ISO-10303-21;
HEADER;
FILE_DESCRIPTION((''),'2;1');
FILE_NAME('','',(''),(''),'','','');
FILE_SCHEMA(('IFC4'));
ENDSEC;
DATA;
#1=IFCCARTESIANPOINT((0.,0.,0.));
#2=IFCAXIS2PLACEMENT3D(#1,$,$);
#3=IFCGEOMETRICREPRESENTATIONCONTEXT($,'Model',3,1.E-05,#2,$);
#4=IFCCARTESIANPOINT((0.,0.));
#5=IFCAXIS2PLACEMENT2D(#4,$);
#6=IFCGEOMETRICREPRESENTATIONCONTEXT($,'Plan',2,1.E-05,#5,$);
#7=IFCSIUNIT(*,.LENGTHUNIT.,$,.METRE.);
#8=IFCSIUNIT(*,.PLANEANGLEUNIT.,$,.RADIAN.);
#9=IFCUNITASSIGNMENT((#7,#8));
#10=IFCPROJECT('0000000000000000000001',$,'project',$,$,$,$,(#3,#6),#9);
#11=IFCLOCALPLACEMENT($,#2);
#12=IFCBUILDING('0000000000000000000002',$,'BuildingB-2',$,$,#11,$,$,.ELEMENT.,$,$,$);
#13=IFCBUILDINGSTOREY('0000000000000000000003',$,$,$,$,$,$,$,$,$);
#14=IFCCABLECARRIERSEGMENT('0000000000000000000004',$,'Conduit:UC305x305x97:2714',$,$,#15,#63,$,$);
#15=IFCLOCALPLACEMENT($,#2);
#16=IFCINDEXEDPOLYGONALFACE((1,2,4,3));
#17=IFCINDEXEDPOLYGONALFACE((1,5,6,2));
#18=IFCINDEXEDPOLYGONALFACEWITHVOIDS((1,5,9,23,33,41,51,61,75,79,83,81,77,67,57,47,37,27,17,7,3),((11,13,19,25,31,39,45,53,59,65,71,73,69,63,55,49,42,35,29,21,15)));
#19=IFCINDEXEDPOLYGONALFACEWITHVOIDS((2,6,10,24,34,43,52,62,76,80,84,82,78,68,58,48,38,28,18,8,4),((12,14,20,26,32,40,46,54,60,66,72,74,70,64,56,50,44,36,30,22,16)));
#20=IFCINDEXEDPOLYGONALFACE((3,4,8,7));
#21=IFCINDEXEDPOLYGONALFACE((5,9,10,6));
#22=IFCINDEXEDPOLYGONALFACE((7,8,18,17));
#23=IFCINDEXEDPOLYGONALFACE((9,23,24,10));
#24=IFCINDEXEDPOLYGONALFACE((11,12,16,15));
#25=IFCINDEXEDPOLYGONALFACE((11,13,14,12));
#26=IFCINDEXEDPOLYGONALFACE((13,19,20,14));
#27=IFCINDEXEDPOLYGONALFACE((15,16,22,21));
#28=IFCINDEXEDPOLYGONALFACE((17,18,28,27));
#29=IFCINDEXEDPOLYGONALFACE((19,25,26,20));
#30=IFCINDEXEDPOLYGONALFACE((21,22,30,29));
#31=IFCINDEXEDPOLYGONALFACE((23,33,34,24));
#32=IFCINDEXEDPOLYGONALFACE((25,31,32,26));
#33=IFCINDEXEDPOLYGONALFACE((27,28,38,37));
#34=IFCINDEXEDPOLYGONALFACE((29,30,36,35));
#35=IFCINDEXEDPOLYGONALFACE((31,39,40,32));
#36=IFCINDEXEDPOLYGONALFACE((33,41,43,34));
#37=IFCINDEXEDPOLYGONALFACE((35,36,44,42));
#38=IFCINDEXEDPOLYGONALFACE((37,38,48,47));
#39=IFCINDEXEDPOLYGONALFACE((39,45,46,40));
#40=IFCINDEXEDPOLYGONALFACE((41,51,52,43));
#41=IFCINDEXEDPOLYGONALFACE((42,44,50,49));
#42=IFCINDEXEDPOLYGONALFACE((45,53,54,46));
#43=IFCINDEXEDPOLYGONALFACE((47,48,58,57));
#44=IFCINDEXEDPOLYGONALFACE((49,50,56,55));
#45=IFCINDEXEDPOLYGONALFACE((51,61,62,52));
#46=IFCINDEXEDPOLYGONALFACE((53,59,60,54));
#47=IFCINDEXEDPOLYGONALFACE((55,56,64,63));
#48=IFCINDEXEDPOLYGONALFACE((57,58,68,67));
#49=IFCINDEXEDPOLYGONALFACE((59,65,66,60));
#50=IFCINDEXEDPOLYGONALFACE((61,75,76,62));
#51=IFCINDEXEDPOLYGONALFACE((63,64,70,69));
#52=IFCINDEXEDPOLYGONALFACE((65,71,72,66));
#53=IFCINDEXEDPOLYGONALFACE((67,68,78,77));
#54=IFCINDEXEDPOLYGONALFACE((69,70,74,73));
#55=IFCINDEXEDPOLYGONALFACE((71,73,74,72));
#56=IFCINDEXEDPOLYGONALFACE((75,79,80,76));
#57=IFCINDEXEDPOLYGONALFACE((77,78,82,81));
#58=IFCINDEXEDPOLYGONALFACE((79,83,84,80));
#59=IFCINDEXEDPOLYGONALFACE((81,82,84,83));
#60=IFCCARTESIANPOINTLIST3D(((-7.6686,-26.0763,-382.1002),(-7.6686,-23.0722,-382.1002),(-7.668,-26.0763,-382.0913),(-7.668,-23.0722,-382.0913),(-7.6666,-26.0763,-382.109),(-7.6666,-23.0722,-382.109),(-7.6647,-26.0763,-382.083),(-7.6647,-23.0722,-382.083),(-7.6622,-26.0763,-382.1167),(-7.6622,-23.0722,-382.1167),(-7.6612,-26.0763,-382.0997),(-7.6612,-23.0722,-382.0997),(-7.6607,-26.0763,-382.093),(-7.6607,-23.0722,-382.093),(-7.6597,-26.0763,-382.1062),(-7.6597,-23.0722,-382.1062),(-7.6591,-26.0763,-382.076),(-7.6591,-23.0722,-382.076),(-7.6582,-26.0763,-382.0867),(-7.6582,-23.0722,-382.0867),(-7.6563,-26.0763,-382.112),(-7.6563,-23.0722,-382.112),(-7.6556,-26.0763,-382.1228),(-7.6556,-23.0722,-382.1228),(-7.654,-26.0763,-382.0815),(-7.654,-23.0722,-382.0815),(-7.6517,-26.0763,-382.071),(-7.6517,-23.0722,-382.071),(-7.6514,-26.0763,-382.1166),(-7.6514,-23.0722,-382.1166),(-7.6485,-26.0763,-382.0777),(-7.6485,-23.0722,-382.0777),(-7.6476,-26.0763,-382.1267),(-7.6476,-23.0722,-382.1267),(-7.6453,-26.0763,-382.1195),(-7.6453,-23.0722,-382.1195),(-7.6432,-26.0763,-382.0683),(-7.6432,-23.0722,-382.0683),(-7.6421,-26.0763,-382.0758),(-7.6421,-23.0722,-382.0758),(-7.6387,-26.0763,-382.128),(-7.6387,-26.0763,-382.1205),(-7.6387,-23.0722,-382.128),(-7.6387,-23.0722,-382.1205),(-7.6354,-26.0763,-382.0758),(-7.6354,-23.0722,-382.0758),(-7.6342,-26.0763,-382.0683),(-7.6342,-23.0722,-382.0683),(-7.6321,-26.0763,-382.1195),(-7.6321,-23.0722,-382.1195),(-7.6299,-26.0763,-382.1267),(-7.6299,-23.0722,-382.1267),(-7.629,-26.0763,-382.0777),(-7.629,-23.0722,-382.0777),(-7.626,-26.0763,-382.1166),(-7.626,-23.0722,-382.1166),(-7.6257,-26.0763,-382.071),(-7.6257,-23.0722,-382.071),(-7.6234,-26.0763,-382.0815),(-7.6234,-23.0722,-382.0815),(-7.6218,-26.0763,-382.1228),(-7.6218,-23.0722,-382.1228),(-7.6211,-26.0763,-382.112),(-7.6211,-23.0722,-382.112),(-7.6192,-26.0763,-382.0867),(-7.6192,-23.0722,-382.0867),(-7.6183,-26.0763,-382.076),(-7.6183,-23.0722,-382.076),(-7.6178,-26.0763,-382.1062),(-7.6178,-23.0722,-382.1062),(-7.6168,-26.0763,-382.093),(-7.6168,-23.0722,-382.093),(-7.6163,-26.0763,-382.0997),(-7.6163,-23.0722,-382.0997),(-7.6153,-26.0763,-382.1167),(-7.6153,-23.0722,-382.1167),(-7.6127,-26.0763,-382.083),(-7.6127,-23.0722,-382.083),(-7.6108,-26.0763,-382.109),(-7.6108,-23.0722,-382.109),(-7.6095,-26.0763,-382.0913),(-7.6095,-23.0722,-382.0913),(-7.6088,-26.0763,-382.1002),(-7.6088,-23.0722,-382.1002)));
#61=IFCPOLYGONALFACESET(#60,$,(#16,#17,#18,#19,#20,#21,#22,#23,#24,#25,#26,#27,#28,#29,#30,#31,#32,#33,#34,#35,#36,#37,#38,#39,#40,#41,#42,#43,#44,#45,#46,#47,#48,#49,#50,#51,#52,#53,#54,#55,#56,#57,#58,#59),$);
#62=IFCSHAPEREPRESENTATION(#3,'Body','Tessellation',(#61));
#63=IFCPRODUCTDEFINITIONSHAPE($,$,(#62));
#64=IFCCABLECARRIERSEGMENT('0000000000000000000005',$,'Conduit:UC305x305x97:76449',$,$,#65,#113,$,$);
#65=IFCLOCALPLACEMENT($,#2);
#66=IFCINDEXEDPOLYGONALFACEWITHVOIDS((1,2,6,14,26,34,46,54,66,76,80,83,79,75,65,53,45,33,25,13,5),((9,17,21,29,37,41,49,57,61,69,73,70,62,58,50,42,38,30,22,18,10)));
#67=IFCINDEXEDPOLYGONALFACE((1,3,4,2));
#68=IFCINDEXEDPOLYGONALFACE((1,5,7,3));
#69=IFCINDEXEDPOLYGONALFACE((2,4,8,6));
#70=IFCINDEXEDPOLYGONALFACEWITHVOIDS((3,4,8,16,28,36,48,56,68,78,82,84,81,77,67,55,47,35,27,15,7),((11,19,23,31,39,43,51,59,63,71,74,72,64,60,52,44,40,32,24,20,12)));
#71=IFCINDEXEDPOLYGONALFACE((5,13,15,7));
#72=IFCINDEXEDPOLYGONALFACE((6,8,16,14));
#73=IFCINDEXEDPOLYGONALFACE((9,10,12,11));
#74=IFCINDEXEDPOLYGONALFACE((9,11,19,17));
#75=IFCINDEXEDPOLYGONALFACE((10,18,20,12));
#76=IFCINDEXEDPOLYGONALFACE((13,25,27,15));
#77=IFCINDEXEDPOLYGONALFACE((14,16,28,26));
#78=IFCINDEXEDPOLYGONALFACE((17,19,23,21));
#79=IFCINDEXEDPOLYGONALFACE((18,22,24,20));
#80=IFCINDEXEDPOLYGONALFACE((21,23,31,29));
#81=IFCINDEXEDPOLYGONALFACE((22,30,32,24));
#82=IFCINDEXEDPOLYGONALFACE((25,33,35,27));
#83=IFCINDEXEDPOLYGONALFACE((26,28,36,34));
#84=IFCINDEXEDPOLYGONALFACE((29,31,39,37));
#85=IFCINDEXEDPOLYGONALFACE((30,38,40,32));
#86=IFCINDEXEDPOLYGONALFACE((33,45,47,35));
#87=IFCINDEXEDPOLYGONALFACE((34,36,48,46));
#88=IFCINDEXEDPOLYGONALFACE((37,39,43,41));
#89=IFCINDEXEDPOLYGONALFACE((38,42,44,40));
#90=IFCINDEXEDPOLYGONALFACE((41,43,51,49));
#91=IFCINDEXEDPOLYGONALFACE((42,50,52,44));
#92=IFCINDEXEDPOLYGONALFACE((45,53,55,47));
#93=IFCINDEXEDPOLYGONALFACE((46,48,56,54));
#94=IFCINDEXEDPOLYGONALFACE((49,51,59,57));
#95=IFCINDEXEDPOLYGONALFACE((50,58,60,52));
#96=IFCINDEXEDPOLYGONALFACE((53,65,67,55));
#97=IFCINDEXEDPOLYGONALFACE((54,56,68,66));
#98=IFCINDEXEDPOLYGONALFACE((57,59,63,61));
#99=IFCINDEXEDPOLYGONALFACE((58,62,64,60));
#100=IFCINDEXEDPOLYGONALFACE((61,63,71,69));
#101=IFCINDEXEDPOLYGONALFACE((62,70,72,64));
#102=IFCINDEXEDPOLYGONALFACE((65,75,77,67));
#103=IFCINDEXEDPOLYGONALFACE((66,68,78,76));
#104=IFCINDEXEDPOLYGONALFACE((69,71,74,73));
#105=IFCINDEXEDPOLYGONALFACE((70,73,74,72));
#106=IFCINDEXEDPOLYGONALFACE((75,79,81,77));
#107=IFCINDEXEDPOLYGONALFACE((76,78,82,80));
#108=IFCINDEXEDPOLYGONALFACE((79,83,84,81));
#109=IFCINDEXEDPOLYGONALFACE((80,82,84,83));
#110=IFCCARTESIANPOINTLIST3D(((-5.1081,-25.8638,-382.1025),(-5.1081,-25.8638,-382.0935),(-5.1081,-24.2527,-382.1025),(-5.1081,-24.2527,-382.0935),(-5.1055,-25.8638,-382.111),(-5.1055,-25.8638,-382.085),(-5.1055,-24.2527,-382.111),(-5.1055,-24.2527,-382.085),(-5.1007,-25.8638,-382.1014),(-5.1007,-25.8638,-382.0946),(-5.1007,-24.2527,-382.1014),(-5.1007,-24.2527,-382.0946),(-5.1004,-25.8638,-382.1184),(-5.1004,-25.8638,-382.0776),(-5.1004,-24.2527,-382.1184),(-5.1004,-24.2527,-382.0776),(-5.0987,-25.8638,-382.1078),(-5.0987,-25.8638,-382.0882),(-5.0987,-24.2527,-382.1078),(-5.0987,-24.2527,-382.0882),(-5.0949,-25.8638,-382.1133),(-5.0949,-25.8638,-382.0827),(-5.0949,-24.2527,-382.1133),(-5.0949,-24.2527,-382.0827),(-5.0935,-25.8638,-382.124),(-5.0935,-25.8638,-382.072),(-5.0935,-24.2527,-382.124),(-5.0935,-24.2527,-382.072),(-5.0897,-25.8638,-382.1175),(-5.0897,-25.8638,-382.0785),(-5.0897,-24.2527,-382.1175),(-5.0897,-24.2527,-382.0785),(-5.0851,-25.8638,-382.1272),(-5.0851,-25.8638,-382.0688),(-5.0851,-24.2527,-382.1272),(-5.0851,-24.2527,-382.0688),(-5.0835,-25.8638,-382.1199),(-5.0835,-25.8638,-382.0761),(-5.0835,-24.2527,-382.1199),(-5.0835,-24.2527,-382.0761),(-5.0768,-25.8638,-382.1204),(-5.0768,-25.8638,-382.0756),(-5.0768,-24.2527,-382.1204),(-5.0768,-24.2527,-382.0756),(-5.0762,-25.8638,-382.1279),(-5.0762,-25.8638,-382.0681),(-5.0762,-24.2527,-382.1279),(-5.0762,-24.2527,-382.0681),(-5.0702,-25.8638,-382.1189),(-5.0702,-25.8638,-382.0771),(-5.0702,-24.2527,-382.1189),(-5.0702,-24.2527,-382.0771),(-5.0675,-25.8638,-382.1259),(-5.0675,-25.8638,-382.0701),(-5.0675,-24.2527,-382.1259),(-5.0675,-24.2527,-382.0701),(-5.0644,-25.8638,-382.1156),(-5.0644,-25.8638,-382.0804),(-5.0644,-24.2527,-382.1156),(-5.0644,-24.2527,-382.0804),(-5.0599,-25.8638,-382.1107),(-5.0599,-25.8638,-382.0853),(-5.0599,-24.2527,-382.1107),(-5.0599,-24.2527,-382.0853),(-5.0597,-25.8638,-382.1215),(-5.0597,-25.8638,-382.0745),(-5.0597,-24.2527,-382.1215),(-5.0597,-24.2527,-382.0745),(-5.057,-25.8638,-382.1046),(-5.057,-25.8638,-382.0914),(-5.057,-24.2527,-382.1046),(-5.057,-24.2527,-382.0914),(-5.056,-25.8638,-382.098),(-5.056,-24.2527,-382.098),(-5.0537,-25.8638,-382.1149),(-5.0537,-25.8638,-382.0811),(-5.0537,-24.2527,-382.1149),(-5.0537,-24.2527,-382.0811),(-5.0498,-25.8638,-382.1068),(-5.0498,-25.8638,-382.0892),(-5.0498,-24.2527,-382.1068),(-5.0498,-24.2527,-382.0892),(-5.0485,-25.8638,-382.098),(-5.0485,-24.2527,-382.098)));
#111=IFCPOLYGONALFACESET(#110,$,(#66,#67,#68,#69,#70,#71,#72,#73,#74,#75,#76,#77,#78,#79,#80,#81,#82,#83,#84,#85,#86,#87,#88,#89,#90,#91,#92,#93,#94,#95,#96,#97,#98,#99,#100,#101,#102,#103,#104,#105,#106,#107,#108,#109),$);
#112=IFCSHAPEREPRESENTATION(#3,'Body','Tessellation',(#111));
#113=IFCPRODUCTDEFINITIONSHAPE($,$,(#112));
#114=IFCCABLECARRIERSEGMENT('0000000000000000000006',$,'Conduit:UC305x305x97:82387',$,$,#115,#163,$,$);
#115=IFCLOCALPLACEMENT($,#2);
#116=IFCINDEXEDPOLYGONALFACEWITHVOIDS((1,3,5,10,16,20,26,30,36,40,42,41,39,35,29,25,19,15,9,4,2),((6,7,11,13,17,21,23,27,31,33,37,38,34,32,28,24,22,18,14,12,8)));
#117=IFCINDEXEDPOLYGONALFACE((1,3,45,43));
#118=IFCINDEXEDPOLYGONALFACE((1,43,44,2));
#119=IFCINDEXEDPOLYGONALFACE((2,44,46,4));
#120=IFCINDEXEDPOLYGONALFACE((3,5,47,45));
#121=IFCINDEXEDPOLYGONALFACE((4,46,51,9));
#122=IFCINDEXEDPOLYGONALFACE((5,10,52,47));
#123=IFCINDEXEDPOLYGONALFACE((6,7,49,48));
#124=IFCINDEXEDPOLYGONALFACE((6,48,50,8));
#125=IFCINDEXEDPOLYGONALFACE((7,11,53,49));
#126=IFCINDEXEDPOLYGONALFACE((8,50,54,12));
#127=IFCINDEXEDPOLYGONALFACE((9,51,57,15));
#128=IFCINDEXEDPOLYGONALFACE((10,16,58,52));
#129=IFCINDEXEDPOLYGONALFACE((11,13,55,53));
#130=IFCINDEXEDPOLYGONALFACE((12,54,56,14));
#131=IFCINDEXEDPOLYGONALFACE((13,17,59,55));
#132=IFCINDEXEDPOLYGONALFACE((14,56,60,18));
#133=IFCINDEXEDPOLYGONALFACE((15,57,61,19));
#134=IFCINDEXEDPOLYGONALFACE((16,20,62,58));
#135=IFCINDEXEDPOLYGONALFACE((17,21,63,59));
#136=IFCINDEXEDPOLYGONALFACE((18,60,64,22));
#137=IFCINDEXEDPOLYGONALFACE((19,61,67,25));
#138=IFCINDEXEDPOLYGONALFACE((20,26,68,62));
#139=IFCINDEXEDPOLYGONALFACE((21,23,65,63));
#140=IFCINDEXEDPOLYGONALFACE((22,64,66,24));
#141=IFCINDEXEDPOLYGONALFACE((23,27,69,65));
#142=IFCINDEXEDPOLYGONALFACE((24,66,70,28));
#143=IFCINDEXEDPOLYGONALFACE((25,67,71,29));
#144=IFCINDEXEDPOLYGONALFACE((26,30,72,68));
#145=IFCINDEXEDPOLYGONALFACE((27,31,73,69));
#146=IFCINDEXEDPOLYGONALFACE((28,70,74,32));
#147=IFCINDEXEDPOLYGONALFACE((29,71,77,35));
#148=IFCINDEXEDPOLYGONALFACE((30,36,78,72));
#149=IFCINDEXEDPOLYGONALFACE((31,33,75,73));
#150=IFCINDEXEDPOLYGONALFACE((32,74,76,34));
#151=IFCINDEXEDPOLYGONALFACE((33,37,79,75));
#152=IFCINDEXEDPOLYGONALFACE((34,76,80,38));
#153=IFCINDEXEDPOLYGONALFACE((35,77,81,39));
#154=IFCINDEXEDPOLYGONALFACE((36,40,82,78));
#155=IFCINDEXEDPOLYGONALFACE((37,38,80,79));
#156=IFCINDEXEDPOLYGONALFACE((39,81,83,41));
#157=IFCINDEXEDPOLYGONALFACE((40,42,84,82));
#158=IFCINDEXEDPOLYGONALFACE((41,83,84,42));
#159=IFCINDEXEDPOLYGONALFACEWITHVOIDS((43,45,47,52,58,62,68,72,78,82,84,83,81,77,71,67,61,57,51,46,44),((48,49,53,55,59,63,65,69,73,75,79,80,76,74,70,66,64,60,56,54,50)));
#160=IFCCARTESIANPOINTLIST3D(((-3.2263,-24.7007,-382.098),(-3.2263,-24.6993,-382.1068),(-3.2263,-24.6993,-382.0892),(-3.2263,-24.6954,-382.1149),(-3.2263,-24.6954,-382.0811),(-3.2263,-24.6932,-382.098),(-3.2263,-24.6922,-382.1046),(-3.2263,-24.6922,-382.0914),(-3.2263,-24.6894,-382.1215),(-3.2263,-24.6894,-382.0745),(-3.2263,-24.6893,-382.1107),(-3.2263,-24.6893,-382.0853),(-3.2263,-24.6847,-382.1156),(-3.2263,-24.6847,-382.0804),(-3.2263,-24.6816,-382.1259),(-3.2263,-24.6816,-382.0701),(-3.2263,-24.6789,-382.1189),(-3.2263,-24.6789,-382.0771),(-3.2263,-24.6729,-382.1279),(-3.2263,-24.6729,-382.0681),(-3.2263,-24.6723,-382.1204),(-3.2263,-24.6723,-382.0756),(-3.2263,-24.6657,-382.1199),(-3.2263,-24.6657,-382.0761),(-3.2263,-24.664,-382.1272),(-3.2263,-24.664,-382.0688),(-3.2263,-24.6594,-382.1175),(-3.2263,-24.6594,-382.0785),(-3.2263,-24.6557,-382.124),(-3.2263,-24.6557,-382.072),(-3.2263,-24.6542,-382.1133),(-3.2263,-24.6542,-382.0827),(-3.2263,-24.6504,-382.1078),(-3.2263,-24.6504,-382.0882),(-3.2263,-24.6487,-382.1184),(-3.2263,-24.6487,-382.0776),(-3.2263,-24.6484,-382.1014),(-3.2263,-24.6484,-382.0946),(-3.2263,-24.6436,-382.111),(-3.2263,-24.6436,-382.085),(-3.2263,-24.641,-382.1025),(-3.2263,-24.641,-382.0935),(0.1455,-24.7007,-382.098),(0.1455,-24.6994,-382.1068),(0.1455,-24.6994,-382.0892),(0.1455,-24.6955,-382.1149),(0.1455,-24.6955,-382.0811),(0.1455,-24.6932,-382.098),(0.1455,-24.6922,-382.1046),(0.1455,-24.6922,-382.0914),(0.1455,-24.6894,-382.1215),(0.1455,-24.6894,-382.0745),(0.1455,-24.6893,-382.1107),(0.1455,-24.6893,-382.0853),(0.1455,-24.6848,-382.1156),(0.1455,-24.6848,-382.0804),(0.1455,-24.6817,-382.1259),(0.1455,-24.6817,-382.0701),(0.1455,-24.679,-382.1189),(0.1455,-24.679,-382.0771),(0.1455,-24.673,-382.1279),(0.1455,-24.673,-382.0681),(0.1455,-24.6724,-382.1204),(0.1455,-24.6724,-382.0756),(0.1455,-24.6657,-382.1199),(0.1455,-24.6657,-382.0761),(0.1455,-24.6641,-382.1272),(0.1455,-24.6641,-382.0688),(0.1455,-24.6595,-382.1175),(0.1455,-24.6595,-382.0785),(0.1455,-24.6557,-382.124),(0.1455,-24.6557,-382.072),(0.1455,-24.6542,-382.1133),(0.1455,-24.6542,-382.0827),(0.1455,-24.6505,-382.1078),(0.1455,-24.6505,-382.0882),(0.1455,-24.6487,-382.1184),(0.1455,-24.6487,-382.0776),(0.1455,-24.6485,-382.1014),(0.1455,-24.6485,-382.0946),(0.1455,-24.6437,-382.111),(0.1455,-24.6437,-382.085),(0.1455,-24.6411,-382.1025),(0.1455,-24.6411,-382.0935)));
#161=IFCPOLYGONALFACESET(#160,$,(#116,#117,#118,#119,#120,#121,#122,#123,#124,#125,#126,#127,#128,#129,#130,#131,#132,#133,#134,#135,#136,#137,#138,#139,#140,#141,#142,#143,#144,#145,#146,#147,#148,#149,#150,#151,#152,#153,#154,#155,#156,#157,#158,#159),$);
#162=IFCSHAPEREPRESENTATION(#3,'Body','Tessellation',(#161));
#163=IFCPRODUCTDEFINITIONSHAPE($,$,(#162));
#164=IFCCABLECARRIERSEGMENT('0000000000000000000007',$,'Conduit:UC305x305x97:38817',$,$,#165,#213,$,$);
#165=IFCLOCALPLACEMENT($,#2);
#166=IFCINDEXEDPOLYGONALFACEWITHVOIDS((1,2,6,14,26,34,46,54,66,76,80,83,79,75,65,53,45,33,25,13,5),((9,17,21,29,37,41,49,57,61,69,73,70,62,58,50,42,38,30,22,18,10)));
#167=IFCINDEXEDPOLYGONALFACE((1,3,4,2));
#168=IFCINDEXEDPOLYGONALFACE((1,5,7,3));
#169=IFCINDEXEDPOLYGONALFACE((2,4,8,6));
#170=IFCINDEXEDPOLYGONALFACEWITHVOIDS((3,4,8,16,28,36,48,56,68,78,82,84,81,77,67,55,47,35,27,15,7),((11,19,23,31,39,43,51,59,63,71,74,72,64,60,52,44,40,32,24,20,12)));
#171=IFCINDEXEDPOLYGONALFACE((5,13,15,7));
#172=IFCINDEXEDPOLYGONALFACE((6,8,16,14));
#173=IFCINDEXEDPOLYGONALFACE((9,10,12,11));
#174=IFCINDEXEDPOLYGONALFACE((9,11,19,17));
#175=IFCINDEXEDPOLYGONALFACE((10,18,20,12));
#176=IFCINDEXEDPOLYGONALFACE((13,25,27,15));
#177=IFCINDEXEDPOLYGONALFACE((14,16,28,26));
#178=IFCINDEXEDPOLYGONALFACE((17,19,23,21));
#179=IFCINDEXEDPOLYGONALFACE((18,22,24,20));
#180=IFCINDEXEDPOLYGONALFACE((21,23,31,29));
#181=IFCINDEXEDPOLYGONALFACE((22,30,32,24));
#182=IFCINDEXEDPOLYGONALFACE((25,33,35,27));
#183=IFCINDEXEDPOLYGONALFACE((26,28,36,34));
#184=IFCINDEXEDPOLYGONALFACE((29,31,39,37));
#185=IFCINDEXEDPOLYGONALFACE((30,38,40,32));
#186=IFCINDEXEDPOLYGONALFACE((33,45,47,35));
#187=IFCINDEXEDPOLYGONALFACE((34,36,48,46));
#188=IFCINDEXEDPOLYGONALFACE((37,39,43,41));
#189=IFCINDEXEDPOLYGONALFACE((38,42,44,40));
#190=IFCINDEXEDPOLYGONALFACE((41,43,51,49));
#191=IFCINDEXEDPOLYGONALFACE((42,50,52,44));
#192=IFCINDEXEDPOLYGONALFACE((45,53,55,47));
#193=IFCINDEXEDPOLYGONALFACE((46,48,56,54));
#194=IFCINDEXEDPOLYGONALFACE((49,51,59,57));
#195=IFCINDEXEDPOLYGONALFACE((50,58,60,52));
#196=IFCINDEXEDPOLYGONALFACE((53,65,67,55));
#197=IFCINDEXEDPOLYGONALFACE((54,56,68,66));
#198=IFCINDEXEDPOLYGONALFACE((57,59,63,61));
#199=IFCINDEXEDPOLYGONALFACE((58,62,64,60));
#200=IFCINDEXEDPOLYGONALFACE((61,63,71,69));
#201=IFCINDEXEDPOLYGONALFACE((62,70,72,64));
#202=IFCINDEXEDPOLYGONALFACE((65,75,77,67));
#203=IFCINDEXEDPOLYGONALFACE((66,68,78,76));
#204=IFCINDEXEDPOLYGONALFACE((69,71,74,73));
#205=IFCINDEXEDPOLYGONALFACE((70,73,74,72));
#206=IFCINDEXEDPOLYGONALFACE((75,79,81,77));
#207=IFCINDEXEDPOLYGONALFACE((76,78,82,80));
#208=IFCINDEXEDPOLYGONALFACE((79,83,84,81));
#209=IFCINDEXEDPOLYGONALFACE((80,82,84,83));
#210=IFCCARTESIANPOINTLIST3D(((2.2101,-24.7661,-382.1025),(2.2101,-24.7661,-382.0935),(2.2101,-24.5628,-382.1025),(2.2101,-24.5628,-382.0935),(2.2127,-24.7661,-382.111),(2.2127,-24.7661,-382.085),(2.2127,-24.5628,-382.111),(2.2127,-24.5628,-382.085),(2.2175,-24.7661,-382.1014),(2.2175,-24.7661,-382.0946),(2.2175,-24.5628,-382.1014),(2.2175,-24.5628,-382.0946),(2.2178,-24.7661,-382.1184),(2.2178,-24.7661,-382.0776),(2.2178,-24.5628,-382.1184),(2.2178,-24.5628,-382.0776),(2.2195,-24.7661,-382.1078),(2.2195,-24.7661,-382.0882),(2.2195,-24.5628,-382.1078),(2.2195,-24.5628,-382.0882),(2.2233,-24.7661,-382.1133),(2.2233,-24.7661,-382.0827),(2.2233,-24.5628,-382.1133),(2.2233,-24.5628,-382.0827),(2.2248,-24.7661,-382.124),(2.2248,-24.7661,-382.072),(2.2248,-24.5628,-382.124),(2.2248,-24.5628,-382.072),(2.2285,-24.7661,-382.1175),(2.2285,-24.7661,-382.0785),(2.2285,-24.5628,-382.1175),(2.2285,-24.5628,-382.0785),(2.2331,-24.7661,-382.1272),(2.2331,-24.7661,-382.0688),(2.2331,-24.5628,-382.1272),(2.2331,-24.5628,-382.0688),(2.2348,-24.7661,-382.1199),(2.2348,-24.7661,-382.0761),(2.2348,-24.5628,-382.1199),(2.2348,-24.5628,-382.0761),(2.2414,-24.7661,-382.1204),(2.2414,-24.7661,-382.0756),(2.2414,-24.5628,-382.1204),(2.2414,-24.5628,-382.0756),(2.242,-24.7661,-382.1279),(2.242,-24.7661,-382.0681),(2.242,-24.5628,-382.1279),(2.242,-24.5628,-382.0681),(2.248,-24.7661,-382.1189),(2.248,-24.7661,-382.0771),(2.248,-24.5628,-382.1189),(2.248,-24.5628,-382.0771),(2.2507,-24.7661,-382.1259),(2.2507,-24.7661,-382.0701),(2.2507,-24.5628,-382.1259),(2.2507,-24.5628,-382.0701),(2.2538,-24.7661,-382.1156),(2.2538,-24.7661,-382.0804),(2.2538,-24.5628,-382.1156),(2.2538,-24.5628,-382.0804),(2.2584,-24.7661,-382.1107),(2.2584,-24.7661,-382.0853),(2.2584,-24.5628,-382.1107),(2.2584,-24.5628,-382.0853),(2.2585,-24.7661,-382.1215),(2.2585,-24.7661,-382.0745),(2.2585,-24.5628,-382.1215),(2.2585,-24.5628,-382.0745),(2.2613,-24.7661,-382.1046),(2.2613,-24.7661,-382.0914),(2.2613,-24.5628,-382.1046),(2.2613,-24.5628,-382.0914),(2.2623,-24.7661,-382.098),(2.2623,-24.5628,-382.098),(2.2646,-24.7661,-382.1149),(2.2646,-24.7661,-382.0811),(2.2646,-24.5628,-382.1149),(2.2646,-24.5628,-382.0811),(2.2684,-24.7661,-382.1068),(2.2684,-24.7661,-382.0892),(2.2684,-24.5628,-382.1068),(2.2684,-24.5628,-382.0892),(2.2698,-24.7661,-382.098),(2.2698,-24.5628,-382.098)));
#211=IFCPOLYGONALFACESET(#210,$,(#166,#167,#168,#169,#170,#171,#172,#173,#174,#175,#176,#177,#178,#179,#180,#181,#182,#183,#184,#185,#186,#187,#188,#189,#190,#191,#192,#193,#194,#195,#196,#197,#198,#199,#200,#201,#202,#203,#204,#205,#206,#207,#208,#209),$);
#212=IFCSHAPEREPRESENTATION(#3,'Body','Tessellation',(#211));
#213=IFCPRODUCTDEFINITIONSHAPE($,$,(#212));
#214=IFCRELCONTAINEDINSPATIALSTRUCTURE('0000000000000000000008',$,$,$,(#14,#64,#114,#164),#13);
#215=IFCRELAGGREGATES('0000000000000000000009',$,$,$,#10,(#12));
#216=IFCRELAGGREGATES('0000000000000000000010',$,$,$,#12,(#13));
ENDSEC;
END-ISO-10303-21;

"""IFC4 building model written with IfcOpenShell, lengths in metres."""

from ifc_helpers import new_model, entity, si_unit, origin, origin_2d, place, context, project, spatial, element, save


model = new_model("IFC4")

# Units and contexts
model_context = context("Model", 3, precision=1e-05, world=origin())
plan_context = context("Plan", 2, precision=1e-05, world=origin_2d())
ifc_project = project(units=[si_unit("LENGTHUNIT", "METRE"), si_unit("PLANEANGLEUNIT", "RADIAN")], contexts=[model_context, plan_context])

# Building, storey
building_placement = place(None, origin())
building = spatial("IfcBuilding", under=ifc_project, at=building_placement, Name="BuildingB-2", CompositionType="ELEMENT")
storey = spatial("IfcBuildingStorey", under=building)

# Cable carrier segments
element("IfcCableCarrierSegment", 1, inside=storey, Name="Conduit:UC305x305x97:2714", context=model_context, shape_type="AdvancedSweptSolid", body=[
    entity("IfcSweptDiskSolid", entity("IfcCompositeCurve", [entity("IfcCompositeCurveSegment", "CONTINUOUS", False, entity("IfcPolyline", [entity("IfcCartesianPoint", [7.6387, 26.0763, 382.098]), entity("IfcCartesianPoint", [7.6387, 23.0722, 382.098])]))], False), 0.03, 0.0225),
])
element("IfcCableCarrierSegment", 2, inside=storey, Name="Conduit:UC305x305x97:76449", context=model_context, shape_type="AdvancedSweptSolid", body=[
    entity("IfcSweptDiskSolid", entity("IfcCompositeCurve", [entity("IfcCompositeCurveSegment", "CONTINUOUS", False, entity("IfcPolyline", [entity("IfcCartesianPoint", [5.0785, 24.2527, 382.098]), entity("IfcCartesianPoint", [5.0785, 25.8638, 382.098])]))], False), 0.03, 0.0225),
])
element("IfcCableCarrierSegment", 3, inside=storey, Name="Conduit:UC305x305x97:82387", context=model_context, shape_type="AdvancedSweptSolid", body=[
    entity("IfcSweptDiskSolid", entity("IfcCompositeCurve", [entity("IfcCompositeCurveSegment", "CONTINUOUS", False, entity("IfcPolyline", [entity("IfcCartesianPoint", [3.2263, 24.6707, 382.098]), entity("IfcCartesianPoint", [-0.1455, 24.6707, 382.098])]))], False), 0.03, 0.0225),
])
element("IfcCableCarrierSegment", 4, inside=storey, Name="Conduit:UC305x305x97:38817", context=model_context, shape_type="AdvancedSweptSolid", body=[
    entity("IfcSweptDiskSolid", entity("IfcCompositeCurve", [entity("IfcCompositeCurveSegment", "CONTINUOUS", False, entity("IfcPolyline", [entity("IfcCartesianPoint", [-2.2398, 24.5628, 382.098]), entity("IfcCartesianPoint", [-2.2398, 24.7661, 382.098])]))], False), 0.03, 0.0225),
])

save(model, "model.ifc")
